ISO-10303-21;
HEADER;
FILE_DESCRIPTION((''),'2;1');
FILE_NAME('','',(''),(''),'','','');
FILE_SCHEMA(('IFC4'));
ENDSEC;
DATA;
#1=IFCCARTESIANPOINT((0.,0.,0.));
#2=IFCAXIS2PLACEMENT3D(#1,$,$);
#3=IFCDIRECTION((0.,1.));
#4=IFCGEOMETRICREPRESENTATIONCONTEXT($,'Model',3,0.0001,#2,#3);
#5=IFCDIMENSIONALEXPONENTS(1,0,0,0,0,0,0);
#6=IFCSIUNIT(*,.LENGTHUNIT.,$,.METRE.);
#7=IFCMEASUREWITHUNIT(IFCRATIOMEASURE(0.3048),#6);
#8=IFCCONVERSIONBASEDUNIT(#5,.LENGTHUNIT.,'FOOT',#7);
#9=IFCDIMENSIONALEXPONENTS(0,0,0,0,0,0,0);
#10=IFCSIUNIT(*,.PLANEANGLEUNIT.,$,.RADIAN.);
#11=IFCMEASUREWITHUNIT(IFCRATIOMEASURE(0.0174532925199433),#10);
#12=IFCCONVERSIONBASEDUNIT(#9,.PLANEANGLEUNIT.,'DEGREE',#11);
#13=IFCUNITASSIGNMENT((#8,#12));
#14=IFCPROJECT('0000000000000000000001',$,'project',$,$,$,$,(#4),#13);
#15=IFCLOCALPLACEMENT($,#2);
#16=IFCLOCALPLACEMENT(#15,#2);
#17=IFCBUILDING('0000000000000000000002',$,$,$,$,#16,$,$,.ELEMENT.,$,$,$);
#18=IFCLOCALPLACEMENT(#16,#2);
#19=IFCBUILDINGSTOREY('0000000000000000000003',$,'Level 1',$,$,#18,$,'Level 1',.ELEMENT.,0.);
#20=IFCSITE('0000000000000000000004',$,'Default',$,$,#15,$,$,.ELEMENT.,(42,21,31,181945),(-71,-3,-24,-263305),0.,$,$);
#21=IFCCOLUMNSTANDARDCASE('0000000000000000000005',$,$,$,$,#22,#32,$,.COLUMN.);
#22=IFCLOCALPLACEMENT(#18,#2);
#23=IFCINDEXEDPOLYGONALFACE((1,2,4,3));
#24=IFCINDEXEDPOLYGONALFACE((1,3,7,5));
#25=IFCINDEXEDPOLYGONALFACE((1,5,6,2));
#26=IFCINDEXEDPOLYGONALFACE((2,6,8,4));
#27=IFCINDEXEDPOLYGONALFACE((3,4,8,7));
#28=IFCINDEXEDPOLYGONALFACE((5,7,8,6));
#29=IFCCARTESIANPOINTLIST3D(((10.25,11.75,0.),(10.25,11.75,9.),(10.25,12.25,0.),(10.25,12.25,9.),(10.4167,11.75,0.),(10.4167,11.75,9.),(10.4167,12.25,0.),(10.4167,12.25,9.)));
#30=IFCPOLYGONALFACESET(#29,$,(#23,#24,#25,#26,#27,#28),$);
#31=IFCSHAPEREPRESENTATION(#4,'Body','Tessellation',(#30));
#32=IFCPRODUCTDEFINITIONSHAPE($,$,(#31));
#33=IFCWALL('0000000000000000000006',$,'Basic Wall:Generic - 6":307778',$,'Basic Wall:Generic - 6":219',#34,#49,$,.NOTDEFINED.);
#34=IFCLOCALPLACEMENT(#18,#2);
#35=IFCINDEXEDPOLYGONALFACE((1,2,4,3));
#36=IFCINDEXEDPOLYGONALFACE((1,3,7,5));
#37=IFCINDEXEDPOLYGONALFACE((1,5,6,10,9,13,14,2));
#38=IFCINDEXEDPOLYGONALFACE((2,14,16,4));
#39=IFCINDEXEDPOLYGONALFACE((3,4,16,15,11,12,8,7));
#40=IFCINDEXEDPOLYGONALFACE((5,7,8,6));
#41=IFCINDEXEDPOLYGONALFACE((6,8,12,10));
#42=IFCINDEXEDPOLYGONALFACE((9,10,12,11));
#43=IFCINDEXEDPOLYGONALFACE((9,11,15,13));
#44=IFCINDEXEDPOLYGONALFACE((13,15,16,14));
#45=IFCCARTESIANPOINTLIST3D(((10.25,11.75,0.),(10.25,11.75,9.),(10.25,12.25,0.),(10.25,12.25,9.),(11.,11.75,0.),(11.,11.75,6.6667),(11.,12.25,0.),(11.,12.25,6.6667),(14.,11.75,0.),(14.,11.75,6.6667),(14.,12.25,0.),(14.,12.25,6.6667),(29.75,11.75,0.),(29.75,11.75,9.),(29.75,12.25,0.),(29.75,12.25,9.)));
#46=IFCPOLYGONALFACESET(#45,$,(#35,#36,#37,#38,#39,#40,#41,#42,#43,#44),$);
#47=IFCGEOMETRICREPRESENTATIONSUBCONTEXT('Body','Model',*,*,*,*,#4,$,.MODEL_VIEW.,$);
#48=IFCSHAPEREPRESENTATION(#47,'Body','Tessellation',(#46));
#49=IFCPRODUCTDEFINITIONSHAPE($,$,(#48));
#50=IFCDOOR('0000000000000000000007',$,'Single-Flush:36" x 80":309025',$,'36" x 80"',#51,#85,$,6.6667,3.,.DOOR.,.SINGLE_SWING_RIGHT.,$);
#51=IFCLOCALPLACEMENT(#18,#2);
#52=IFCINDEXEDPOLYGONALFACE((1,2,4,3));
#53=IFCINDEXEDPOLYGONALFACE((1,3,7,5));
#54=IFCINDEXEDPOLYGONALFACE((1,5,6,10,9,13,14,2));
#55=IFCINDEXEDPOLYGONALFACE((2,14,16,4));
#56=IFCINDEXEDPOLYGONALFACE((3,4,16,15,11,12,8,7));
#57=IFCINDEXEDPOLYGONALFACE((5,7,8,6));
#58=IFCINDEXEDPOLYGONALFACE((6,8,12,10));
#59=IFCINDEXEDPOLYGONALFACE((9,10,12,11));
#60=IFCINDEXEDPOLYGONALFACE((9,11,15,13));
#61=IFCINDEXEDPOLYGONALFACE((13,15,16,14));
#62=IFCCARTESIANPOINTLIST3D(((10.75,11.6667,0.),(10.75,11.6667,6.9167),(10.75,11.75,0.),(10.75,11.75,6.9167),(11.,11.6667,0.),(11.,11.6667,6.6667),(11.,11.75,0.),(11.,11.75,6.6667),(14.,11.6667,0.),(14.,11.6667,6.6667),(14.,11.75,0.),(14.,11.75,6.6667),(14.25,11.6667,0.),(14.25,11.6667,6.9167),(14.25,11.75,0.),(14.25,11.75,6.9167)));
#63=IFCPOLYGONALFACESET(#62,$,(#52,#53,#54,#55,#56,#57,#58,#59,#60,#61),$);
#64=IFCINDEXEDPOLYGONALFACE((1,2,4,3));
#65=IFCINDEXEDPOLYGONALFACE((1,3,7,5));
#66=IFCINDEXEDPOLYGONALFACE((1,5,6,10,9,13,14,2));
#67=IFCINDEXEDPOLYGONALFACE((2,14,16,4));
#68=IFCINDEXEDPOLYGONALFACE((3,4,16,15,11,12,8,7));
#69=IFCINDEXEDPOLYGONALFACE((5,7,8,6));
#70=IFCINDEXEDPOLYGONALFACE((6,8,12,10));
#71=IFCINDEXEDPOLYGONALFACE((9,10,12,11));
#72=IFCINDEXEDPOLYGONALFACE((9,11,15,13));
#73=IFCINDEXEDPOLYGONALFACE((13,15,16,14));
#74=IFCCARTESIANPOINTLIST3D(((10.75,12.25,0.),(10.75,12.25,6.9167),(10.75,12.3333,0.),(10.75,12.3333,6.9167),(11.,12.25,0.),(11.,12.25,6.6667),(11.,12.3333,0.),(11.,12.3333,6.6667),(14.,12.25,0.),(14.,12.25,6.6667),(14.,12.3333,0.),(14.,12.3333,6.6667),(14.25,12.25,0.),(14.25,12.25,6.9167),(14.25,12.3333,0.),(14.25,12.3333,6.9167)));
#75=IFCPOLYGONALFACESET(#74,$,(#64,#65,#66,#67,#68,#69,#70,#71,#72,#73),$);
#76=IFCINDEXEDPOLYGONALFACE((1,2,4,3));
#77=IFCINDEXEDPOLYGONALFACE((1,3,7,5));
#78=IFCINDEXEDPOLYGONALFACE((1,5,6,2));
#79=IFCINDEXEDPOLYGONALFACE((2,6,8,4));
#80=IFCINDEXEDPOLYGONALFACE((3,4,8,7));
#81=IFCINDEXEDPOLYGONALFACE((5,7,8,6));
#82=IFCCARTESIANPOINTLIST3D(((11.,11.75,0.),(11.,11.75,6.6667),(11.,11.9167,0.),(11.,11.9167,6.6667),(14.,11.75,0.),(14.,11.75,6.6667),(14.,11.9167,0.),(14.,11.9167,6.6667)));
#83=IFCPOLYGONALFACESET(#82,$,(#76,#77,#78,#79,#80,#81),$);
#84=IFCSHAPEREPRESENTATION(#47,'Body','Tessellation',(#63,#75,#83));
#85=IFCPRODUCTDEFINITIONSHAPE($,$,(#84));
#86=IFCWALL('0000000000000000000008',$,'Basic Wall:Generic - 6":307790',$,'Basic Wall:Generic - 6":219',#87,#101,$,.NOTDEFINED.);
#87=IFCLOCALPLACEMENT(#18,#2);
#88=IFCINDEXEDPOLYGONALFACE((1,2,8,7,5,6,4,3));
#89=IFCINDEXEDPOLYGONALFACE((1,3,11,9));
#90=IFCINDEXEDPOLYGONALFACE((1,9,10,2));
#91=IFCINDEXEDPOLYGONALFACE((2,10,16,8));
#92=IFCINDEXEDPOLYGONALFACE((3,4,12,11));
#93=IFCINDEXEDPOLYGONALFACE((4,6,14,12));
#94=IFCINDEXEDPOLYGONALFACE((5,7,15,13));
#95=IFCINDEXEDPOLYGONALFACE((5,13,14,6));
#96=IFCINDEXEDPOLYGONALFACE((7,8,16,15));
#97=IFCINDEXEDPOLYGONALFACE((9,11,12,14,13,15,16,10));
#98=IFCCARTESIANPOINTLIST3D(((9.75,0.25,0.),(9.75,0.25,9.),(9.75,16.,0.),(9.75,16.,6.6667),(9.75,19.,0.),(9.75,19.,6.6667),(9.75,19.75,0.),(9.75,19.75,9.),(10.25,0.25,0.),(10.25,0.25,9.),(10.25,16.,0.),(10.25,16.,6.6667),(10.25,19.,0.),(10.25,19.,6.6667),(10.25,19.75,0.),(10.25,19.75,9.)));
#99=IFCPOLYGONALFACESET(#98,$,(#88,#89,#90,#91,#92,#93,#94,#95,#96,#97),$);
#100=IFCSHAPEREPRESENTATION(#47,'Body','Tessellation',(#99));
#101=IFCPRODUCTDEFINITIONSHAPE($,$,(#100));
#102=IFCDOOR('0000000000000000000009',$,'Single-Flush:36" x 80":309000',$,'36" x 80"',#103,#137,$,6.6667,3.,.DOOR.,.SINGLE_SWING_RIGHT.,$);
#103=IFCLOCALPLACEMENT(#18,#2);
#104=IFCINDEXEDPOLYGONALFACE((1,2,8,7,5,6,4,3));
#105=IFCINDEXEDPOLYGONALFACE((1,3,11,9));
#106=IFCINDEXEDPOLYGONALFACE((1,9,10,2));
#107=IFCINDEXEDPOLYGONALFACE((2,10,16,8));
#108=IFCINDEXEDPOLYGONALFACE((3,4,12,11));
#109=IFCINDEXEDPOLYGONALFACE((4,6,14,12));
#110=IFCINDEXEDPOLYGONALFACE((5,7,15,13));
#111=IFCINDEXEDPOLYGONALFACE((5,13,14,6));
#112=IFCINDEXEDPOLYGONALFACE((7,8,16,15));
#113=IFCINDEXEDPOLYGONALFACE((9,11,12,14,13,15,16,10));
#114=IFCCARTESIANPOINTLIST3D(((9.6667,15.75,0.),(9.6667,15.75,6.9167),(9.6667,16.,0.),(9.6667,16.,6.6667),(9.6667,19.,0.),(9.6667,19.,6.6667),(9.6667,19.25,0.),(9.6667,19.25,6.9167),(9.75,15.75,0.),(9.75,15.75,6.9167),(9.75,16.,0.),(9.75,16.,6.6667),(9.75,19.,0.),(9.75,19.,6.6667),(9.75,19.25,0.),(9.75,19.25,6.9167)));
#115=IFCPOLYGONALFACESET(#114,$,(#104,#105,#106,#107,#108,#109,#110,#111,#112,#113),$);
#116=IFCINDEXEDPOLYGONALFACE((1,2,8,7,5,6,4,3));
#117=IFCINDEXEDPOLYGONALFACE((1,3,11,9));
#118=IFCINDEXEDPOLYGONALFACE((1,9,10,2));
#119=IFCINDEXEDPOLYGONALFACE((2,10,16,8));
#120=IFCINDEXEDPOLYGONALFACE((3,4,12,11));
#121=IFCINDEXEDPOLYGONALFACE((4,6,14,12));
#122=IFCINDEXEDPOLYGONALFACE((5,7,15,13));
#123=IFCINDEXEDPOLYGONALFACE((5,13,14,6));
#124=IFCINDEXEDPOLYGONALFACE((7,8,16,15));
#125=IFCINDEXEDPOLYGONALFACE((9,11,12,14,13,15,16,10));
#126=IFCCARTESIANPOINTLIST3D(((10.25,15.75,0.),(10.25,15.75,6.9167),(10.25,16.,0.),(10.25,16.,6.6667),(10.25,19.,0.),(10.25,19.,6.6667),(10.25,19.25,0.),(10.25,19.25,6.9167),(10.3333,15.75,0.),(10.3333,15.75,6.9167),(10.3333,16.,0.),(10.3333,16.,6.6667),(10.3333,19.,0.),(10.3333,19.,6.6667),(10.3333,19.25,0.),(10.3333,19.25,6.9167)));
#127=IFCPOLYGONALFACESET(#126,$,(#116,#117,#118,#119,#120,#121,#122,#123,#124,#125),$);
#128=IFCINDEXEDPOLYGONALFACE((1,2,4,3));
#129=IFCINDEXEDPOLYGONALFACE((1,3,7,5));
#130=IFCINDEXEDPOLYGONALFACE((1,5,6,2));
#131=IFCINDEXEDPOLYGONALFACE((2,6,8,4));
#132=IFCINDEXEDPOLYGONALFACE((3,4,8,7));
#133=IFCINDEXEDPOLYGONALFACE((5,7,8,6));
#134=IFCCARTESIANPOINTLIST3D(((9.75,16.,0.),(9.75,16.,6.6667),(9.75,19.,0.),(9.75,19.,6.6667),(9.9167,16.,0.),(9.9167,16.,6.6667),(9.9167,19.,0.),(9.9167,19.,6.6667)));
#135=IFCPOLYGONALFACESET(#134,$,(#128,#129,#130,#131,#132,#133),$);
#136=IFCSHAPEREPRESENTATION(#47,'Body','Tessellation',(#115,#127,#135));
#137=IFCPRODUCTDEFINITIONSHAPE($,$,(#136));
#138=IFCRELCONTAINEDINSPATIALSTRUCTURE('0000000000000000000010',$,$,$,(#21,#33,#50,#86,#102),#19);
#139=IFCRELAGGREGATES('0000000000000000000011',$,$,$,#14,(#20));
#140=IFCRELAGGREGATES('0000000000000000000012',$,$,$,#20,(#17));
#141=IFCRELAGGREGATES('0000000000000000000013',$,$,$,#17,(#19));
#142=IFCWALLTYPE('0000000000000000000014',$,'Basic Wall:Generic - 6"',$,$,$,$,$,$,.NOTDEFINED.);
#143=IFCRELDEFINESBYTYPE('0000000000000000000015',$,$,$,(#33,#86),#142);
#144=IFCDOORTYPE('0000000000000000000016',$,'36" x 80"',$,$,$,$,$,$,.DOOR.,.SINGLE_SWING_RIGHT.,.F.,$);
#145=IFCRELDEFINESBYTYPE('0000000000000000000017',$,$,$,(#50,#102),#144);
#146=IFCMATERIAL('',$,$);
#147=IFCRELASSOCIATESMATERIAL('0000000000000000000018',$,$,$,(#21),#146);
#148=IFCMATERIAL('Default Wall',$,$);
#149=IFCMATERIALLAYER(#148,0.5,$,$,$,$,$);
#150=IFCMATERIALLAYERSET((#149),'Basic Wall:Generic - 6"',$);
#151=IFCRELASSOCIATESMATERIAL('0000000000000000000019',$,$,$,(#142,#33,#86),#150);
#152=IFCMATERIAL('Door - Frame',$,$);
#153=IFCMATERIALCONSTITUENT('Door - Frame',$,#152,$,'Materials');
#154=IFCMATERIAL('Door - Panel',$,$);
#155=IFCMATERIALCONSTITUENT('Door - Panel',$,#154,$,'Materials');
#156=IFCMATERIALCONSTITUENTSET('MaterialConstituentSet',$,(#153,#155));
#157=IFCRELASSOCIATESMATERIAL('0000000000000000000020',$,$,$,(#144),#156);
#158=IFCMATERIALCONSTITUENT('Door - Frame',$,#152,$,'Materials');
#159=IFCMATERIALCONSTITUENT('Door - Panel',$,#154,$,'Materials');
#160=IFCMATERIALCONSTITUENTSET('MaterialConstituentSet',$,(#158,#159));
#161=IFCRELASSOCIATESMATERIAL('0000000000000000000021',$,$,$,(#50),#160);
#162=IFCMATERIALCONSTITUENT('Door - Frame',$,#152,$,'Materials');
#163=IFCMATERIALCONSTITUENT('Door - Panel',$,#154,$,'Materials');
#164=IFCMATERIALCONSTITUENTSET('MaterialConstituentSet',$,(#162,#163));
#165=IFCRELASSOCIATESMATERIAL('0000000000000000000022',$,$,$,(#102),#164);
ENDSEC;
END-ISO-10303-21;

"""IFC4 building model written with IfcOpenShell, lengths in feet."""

from ifc_helpers import new_model, entity, si_unit, converted_unit, direction, frame, frame_2d, origin, origin_2d_with_axis, place, context, subcontext, project, spatial, polyline, rectangle, outline, extrude, clip, bounded_halfspace, source, transform, mapped, material, layer, layer_set, layer_usage, constituent, constituent_set, type_object, type_shapes, element, fill, save


model = new_model("IFC4")

# Units and contexts
model_context = context("Model", 3, precision=0.0001, world=origin(), true_north=direction((0.0, 1.0)))
body_context = subcontext(model_context, "Body", "Model", "MODEL_VIEW")
ifc_project = project(units=[converted_unit("LENGTHUNIT", "FOOT", entity("IfcRatioMeasure", 0.3048), si_unit("LENGTHUNIT", "METRE"), dimensions=[1, 0, 0, 0, 0, 0, 0]), converted_unit("PLANEANGLEUNIT", "DEGREE", entity("IfcRatioMeasure", 0.0174532925199433), si_unit("PLANEANGLEUNIT", "RADIAN"), dimensions=[0, 0, 0, 0, 0, 0, 0])], contexts=[model_context])

# Site, building, storey
site_placement = place(None, origin())
site = spatial("IfcSite", under=ifc_project, at=site_placement, Name="Default", CompositionType="ELEMENT", RefLatitude=(42, 21, 31, 181945), RefLongitude=(-71, -3, -24, -263305), RefElevation=0.0)
building_placement = place(site_placement, origin())
building = spatial("IfcBuilding", under=site, at=building_placement, CompositionType="ELEMENT")
storey_placement = place(building_placement, origin())
storey = spatial("IfcBuildingStorey", under=building, at=storey_placement, Name="Level 1", LongName="Level 1", CompositionType="ELEMENT", Elevation=0.0)

# Column
ifc_material_1 = material(Name="")
wall_1_placement = place(storey_placement, frame((10.25, 12.0, 0.0)))
for number, where, z_axis, x_axis in (
    (1, (0.0833, 0.0, 0.0), (0.0, 0.0, 1.0), (1.0, 0.0, 0.0)),
):
    element("IfcColumnStandardCase", number, at=place(wall_1_placement, frame(where, z_axis=z_axis, x_axis=x_axis)), inside=storey, material=ifc_material_1, PredefinedType="COLUMN", context=model_context, shape_type="SweptSolid", body=[
        extrude(rectangle(XDim=0.1667, YDim=0.5), origin(), (0.0, 0.0, 1.0), 9.0),
    ])
wall_2_placement = place(storey_placement, frame((10.0, 19.75, 0.0), z_axis=(0.0, 0.0, 1.0), x_axis=(0.0, -1.0, 0.0)))

# Walls, openings, doors
ifc_material_2 = material(Name="Default Wall")
ifc_layer = layer(ifc_material_2, 0.5)
ifc_layer_set = layer_set([ifc_layer], Name="Basic Wall:Generic - 6\"")
ifc_layer_usage_1 = layer_usage(ifc_layer_set, "AXIS2", "NEGATIVE", 0.25)
wall_type = type_object("IfcWallType", Name="Basic Wall:Generic - 6\"", PredefinedType="NOTDEFINED", material=ifc_layer_set)
wall_1 = element("IfcWall", 2, at=wall_1_placement, inside=storey, type_object=wall_type, material=ifc_layer_usage_1, Name="Basic Wall:Generic - 6\":307778", ObjectType="Basic Wall:Generic - 6\":219", PredefinedType="NOTDEFINED", context=body_context, shape_type="Clipping", body=[
    clip(extrude(rectangle(XDim=19.5, YDim=0.5, at=frame_2d((9.75, 0.0), x_axis=(-1.0, 0.0))), origin(), (0.0, 0.0, 1.0), 9.0), bounded_halfspace(frame((0.0, -0.25, 9.0), z_axis=(0.0, 0.0, -1.0), x_axis=(0.0, -1.0, 0.0)), True, frame((0.0, -0.25, 9.0)), polyline([(0.0, 0.0), (19.5, 0.0), (19.5, 0.5), (0.0, 0.5), (0.0, 0.0)]))),
])
opening_1_placement = place(wall_1_placement, frame((3.75, 0.25, 0.0)))
opening_1 = element("IfcOpeningElement", 3, at=opening_1_placement, cuts=wall_1, ObjectType="Opening", PredefinedType="OPENING", context=body_context, shape_type="SweptSolid", body=[
    extrude(rectangle(XDim=3.0, YDim=6.6667, at=frame_2d((3.3333, 1.5), x_axis=(0.0, 1.0))), frame((0.0, 0.0, 0.0), z_axis=(0.0, -1.0, 0.0), x_axis=(0.0, 0.0, 1.0)), (0.0, 0.0, 1.0), 0.5),
])
ifc_material_3 = material(Name="Door - Frame")
ifc_constituent_1 = constituent(ifc_material_3, Name="Door - Frame", Category="Materials")
ifc_material_4 = material(Name="Door - Panel")
ifc_constituent_2 = constituent(ifc_material_4, Name="Door - Panel", Category="Materials")
ifc_constituent_set_1 = constituent_set(constituents=[ifc_constituent_1, ifc_constituent_2], Name="MaterialConstituentSet")
ifc_constituent_3 = constituent(ifc_material_3, Name="Door - Frame", Category="Materials")
ifc_constituent_4 = constituent(ifc_material_4, Name="Door - Panel", Category="Materials")
ifc_constituent_set_2 = constituent_set(constituents=[ifc_constituent_3, ifc_constituent_4], Name="MaterialConstituentSet")
door_type = type_object("IfcDoorType", Name="36\" x 80\"", OperationType="SINGLE_SWING_RIGHT", ParameterTakesPrecedence=False, PredefinedType="DOOR", material=ifc_constituent_set_2)
shared_shape = source(origin(), body_context, "Body", "SweptSolid", [
    extrude(outline(polyline([(-1.75, -3.5208), (1.75, -3.5208), (1.75, 3.3958), (1.5, 3.3958), (1.5, -3.2708), (-1.5, -3.2708), (-1.5, 3.3958), (-1.75, 3.3958), (-1.75, -3.5208)])), frame((1.5, 0.5, 3.3958), z_axis=(0.0, 1.0, 0.0), x_axis=(1.0, 0.0, 0.0)), (0.0, 0.0, 1.0), 0.0833),
    extrude(outline(polyline([(-3.5208, -1.75), (3.3958, -1.75), (3.3958, -1.5), (-3.2708, -1.5), (-3.2708, 1.5), (3.3958, 1.5), (3.3958, 1.75), (-3.5208, 1.75), (-3.5208, -1.75)])), frame((1.5, -0.0833, 3.3958), z_axis=(0.0, 1.0, 0.0), x_axis=(0.0, 0.0, -1.0)), (0.0, 0.0, 1.0), 0.0833),
    extrude(rectangle(XDim=0.1667, YDim=3.0, at=origin_2d_with_axis()), frame((1.5, 0.4167, 0.0), z_axis=(0.0, 0.0, 1.0), x_axis=(0.0, 1.0, 0.0)), (0.0, 0.0, 1.0), 6.6667),
])
type_shapes(door_type, [shared_shape])
door_1_placement = place(opening_1_placement, frame((0.0, 0.0, 0.0), z_axis=(0.0, 0.0, 1.0), x_axis=(-1.0, 0.0, 0.0)))
door_1 = element("IfcDoor", 4, at=door_1_placement, inside=storey, type_object=door_type, material=ifc_constituent_set_1, Name="Single-Flush:36\" x 80\":309025", ObjectType="36\" x 80\"", OperationType="SINGLE_SWING_RIGHT", OverallHeight=6.6667, OverallWidth=3.0, PredefinedType="DOOR", context=body_context, shape_type="MappedRepresentation", body=[
    mapped(shared_shape, transform((0.0, 0.0, 0.0), scale=1.0)),
])
fill(opening_1, door_1)
ifc_layer_usage_2 = layer_usage(ifc_layer_set, "AXIS2", "NEGATIVE", 0.25)
wall_2 = element("IfcWall", 5, at=wall_2_placement, inside=storey, type_object=wall_type, material=ifc_layer_usage_2, Name="Basic Wall:Generic - 6\":307790", ObjectType="Basic Wall:Generic - 6\":219", PredefinedType="NOTDEFINED", context=body_context, shape_type="Clipping", body=[
    clip(clip(extrude(rectangle(XDim=19.5, YDim=0.5, at=frame_2d((9.75, 0.0), x_axis=(-1.0, 0.0))), origin(), (0.0, 0.0, 1.0), 9.0), bounded_halfspace(frame((8.0, -0.25, 9.0), z_axis=(0.0, 0.0, -1.0), x_axis=(0.0, 1.0, 0.0)), True, frame((8.0, -0.25, 9.0)), polyline([(0.0, 0.0), (11.5, 0.0), (11.5, 0.5), (0.0, 0.5), (0.0, 0.0)]))), bounded_halfspace(frame((8.0, -0.25, 9.0), z_axis=(0.0, 0.0, -1.0), x_axis=(1.0, 0.0, 0.0)), True, frame((8.0, -0.25, 9.0)), polyline([(0.0, 0.0), (0.0, 0.5), (-0.5, 0.5), (-8.0, 0.5), (-8.0, 0.0), (0.0, 0.0)]))),
])
opening_2_placement = place(wall_2_placement, frame((3.75, 0.25, 0.0)))
opening_2 = element("IfcOpeningElement", 6, at=opening_2_placement, cuts=wall_2, ObjectType="Opening", PredefinedType="OPENING", context=body_context, shape_type="SweptSolid", body=[
    extrude(rectangle(XDim=3.0, YDim=6.6667, at=frame_2d((3.3333, 1.5), x_axis=(0.0, 1.0))), frame((0.0, 0.0, 0.0), z_axis=(0.0, -1.0, 0.0), x_axis=(0.0, 0.0, 1.0)), (0.0, 0.0, 1.0), 0.5),
])
ifc_constituent_5 = constituent(ifc_material_3, Name="Door - Frame", Category="Materials")
ifc_constituent_6 = constituent(ifc_material_4, Name="Door - Panel", Category="Materials")
ifc_constituent_set_3 = constituent_set(constituents=[ifc_constituent_5, ifc_constituent_6], Name="MaterialConstituentSet")
door_2_placement = place(opening_2_placement, frame((0.0, 0.0, 0.0), z_axis=(0.0, 0.0, 1.0), x_axis=(-1.0, 0.0, 0.0)))
door_2 = element("IfcDoor", 7, at=door_2_placement, inside=storey, type_object=door_type, material=ifc_constituent_set_3, Name="Single-Flush:36\" x 80\":309000", ObjectType="36\" x 80\"", OperationType="SINGLE_SWING_RIGHT", OverallHeight=6.6667, OverallWidth=3.0, PredefinedType="DOOR", context=body_context, shape_type="MappedRepresentation", body=[
    mapped(shared_shape, transform((0.0, 0.0, 0.0), scale=1.0)),
])
fill(opening_2, door_2)

save(model, "model.ifc")
